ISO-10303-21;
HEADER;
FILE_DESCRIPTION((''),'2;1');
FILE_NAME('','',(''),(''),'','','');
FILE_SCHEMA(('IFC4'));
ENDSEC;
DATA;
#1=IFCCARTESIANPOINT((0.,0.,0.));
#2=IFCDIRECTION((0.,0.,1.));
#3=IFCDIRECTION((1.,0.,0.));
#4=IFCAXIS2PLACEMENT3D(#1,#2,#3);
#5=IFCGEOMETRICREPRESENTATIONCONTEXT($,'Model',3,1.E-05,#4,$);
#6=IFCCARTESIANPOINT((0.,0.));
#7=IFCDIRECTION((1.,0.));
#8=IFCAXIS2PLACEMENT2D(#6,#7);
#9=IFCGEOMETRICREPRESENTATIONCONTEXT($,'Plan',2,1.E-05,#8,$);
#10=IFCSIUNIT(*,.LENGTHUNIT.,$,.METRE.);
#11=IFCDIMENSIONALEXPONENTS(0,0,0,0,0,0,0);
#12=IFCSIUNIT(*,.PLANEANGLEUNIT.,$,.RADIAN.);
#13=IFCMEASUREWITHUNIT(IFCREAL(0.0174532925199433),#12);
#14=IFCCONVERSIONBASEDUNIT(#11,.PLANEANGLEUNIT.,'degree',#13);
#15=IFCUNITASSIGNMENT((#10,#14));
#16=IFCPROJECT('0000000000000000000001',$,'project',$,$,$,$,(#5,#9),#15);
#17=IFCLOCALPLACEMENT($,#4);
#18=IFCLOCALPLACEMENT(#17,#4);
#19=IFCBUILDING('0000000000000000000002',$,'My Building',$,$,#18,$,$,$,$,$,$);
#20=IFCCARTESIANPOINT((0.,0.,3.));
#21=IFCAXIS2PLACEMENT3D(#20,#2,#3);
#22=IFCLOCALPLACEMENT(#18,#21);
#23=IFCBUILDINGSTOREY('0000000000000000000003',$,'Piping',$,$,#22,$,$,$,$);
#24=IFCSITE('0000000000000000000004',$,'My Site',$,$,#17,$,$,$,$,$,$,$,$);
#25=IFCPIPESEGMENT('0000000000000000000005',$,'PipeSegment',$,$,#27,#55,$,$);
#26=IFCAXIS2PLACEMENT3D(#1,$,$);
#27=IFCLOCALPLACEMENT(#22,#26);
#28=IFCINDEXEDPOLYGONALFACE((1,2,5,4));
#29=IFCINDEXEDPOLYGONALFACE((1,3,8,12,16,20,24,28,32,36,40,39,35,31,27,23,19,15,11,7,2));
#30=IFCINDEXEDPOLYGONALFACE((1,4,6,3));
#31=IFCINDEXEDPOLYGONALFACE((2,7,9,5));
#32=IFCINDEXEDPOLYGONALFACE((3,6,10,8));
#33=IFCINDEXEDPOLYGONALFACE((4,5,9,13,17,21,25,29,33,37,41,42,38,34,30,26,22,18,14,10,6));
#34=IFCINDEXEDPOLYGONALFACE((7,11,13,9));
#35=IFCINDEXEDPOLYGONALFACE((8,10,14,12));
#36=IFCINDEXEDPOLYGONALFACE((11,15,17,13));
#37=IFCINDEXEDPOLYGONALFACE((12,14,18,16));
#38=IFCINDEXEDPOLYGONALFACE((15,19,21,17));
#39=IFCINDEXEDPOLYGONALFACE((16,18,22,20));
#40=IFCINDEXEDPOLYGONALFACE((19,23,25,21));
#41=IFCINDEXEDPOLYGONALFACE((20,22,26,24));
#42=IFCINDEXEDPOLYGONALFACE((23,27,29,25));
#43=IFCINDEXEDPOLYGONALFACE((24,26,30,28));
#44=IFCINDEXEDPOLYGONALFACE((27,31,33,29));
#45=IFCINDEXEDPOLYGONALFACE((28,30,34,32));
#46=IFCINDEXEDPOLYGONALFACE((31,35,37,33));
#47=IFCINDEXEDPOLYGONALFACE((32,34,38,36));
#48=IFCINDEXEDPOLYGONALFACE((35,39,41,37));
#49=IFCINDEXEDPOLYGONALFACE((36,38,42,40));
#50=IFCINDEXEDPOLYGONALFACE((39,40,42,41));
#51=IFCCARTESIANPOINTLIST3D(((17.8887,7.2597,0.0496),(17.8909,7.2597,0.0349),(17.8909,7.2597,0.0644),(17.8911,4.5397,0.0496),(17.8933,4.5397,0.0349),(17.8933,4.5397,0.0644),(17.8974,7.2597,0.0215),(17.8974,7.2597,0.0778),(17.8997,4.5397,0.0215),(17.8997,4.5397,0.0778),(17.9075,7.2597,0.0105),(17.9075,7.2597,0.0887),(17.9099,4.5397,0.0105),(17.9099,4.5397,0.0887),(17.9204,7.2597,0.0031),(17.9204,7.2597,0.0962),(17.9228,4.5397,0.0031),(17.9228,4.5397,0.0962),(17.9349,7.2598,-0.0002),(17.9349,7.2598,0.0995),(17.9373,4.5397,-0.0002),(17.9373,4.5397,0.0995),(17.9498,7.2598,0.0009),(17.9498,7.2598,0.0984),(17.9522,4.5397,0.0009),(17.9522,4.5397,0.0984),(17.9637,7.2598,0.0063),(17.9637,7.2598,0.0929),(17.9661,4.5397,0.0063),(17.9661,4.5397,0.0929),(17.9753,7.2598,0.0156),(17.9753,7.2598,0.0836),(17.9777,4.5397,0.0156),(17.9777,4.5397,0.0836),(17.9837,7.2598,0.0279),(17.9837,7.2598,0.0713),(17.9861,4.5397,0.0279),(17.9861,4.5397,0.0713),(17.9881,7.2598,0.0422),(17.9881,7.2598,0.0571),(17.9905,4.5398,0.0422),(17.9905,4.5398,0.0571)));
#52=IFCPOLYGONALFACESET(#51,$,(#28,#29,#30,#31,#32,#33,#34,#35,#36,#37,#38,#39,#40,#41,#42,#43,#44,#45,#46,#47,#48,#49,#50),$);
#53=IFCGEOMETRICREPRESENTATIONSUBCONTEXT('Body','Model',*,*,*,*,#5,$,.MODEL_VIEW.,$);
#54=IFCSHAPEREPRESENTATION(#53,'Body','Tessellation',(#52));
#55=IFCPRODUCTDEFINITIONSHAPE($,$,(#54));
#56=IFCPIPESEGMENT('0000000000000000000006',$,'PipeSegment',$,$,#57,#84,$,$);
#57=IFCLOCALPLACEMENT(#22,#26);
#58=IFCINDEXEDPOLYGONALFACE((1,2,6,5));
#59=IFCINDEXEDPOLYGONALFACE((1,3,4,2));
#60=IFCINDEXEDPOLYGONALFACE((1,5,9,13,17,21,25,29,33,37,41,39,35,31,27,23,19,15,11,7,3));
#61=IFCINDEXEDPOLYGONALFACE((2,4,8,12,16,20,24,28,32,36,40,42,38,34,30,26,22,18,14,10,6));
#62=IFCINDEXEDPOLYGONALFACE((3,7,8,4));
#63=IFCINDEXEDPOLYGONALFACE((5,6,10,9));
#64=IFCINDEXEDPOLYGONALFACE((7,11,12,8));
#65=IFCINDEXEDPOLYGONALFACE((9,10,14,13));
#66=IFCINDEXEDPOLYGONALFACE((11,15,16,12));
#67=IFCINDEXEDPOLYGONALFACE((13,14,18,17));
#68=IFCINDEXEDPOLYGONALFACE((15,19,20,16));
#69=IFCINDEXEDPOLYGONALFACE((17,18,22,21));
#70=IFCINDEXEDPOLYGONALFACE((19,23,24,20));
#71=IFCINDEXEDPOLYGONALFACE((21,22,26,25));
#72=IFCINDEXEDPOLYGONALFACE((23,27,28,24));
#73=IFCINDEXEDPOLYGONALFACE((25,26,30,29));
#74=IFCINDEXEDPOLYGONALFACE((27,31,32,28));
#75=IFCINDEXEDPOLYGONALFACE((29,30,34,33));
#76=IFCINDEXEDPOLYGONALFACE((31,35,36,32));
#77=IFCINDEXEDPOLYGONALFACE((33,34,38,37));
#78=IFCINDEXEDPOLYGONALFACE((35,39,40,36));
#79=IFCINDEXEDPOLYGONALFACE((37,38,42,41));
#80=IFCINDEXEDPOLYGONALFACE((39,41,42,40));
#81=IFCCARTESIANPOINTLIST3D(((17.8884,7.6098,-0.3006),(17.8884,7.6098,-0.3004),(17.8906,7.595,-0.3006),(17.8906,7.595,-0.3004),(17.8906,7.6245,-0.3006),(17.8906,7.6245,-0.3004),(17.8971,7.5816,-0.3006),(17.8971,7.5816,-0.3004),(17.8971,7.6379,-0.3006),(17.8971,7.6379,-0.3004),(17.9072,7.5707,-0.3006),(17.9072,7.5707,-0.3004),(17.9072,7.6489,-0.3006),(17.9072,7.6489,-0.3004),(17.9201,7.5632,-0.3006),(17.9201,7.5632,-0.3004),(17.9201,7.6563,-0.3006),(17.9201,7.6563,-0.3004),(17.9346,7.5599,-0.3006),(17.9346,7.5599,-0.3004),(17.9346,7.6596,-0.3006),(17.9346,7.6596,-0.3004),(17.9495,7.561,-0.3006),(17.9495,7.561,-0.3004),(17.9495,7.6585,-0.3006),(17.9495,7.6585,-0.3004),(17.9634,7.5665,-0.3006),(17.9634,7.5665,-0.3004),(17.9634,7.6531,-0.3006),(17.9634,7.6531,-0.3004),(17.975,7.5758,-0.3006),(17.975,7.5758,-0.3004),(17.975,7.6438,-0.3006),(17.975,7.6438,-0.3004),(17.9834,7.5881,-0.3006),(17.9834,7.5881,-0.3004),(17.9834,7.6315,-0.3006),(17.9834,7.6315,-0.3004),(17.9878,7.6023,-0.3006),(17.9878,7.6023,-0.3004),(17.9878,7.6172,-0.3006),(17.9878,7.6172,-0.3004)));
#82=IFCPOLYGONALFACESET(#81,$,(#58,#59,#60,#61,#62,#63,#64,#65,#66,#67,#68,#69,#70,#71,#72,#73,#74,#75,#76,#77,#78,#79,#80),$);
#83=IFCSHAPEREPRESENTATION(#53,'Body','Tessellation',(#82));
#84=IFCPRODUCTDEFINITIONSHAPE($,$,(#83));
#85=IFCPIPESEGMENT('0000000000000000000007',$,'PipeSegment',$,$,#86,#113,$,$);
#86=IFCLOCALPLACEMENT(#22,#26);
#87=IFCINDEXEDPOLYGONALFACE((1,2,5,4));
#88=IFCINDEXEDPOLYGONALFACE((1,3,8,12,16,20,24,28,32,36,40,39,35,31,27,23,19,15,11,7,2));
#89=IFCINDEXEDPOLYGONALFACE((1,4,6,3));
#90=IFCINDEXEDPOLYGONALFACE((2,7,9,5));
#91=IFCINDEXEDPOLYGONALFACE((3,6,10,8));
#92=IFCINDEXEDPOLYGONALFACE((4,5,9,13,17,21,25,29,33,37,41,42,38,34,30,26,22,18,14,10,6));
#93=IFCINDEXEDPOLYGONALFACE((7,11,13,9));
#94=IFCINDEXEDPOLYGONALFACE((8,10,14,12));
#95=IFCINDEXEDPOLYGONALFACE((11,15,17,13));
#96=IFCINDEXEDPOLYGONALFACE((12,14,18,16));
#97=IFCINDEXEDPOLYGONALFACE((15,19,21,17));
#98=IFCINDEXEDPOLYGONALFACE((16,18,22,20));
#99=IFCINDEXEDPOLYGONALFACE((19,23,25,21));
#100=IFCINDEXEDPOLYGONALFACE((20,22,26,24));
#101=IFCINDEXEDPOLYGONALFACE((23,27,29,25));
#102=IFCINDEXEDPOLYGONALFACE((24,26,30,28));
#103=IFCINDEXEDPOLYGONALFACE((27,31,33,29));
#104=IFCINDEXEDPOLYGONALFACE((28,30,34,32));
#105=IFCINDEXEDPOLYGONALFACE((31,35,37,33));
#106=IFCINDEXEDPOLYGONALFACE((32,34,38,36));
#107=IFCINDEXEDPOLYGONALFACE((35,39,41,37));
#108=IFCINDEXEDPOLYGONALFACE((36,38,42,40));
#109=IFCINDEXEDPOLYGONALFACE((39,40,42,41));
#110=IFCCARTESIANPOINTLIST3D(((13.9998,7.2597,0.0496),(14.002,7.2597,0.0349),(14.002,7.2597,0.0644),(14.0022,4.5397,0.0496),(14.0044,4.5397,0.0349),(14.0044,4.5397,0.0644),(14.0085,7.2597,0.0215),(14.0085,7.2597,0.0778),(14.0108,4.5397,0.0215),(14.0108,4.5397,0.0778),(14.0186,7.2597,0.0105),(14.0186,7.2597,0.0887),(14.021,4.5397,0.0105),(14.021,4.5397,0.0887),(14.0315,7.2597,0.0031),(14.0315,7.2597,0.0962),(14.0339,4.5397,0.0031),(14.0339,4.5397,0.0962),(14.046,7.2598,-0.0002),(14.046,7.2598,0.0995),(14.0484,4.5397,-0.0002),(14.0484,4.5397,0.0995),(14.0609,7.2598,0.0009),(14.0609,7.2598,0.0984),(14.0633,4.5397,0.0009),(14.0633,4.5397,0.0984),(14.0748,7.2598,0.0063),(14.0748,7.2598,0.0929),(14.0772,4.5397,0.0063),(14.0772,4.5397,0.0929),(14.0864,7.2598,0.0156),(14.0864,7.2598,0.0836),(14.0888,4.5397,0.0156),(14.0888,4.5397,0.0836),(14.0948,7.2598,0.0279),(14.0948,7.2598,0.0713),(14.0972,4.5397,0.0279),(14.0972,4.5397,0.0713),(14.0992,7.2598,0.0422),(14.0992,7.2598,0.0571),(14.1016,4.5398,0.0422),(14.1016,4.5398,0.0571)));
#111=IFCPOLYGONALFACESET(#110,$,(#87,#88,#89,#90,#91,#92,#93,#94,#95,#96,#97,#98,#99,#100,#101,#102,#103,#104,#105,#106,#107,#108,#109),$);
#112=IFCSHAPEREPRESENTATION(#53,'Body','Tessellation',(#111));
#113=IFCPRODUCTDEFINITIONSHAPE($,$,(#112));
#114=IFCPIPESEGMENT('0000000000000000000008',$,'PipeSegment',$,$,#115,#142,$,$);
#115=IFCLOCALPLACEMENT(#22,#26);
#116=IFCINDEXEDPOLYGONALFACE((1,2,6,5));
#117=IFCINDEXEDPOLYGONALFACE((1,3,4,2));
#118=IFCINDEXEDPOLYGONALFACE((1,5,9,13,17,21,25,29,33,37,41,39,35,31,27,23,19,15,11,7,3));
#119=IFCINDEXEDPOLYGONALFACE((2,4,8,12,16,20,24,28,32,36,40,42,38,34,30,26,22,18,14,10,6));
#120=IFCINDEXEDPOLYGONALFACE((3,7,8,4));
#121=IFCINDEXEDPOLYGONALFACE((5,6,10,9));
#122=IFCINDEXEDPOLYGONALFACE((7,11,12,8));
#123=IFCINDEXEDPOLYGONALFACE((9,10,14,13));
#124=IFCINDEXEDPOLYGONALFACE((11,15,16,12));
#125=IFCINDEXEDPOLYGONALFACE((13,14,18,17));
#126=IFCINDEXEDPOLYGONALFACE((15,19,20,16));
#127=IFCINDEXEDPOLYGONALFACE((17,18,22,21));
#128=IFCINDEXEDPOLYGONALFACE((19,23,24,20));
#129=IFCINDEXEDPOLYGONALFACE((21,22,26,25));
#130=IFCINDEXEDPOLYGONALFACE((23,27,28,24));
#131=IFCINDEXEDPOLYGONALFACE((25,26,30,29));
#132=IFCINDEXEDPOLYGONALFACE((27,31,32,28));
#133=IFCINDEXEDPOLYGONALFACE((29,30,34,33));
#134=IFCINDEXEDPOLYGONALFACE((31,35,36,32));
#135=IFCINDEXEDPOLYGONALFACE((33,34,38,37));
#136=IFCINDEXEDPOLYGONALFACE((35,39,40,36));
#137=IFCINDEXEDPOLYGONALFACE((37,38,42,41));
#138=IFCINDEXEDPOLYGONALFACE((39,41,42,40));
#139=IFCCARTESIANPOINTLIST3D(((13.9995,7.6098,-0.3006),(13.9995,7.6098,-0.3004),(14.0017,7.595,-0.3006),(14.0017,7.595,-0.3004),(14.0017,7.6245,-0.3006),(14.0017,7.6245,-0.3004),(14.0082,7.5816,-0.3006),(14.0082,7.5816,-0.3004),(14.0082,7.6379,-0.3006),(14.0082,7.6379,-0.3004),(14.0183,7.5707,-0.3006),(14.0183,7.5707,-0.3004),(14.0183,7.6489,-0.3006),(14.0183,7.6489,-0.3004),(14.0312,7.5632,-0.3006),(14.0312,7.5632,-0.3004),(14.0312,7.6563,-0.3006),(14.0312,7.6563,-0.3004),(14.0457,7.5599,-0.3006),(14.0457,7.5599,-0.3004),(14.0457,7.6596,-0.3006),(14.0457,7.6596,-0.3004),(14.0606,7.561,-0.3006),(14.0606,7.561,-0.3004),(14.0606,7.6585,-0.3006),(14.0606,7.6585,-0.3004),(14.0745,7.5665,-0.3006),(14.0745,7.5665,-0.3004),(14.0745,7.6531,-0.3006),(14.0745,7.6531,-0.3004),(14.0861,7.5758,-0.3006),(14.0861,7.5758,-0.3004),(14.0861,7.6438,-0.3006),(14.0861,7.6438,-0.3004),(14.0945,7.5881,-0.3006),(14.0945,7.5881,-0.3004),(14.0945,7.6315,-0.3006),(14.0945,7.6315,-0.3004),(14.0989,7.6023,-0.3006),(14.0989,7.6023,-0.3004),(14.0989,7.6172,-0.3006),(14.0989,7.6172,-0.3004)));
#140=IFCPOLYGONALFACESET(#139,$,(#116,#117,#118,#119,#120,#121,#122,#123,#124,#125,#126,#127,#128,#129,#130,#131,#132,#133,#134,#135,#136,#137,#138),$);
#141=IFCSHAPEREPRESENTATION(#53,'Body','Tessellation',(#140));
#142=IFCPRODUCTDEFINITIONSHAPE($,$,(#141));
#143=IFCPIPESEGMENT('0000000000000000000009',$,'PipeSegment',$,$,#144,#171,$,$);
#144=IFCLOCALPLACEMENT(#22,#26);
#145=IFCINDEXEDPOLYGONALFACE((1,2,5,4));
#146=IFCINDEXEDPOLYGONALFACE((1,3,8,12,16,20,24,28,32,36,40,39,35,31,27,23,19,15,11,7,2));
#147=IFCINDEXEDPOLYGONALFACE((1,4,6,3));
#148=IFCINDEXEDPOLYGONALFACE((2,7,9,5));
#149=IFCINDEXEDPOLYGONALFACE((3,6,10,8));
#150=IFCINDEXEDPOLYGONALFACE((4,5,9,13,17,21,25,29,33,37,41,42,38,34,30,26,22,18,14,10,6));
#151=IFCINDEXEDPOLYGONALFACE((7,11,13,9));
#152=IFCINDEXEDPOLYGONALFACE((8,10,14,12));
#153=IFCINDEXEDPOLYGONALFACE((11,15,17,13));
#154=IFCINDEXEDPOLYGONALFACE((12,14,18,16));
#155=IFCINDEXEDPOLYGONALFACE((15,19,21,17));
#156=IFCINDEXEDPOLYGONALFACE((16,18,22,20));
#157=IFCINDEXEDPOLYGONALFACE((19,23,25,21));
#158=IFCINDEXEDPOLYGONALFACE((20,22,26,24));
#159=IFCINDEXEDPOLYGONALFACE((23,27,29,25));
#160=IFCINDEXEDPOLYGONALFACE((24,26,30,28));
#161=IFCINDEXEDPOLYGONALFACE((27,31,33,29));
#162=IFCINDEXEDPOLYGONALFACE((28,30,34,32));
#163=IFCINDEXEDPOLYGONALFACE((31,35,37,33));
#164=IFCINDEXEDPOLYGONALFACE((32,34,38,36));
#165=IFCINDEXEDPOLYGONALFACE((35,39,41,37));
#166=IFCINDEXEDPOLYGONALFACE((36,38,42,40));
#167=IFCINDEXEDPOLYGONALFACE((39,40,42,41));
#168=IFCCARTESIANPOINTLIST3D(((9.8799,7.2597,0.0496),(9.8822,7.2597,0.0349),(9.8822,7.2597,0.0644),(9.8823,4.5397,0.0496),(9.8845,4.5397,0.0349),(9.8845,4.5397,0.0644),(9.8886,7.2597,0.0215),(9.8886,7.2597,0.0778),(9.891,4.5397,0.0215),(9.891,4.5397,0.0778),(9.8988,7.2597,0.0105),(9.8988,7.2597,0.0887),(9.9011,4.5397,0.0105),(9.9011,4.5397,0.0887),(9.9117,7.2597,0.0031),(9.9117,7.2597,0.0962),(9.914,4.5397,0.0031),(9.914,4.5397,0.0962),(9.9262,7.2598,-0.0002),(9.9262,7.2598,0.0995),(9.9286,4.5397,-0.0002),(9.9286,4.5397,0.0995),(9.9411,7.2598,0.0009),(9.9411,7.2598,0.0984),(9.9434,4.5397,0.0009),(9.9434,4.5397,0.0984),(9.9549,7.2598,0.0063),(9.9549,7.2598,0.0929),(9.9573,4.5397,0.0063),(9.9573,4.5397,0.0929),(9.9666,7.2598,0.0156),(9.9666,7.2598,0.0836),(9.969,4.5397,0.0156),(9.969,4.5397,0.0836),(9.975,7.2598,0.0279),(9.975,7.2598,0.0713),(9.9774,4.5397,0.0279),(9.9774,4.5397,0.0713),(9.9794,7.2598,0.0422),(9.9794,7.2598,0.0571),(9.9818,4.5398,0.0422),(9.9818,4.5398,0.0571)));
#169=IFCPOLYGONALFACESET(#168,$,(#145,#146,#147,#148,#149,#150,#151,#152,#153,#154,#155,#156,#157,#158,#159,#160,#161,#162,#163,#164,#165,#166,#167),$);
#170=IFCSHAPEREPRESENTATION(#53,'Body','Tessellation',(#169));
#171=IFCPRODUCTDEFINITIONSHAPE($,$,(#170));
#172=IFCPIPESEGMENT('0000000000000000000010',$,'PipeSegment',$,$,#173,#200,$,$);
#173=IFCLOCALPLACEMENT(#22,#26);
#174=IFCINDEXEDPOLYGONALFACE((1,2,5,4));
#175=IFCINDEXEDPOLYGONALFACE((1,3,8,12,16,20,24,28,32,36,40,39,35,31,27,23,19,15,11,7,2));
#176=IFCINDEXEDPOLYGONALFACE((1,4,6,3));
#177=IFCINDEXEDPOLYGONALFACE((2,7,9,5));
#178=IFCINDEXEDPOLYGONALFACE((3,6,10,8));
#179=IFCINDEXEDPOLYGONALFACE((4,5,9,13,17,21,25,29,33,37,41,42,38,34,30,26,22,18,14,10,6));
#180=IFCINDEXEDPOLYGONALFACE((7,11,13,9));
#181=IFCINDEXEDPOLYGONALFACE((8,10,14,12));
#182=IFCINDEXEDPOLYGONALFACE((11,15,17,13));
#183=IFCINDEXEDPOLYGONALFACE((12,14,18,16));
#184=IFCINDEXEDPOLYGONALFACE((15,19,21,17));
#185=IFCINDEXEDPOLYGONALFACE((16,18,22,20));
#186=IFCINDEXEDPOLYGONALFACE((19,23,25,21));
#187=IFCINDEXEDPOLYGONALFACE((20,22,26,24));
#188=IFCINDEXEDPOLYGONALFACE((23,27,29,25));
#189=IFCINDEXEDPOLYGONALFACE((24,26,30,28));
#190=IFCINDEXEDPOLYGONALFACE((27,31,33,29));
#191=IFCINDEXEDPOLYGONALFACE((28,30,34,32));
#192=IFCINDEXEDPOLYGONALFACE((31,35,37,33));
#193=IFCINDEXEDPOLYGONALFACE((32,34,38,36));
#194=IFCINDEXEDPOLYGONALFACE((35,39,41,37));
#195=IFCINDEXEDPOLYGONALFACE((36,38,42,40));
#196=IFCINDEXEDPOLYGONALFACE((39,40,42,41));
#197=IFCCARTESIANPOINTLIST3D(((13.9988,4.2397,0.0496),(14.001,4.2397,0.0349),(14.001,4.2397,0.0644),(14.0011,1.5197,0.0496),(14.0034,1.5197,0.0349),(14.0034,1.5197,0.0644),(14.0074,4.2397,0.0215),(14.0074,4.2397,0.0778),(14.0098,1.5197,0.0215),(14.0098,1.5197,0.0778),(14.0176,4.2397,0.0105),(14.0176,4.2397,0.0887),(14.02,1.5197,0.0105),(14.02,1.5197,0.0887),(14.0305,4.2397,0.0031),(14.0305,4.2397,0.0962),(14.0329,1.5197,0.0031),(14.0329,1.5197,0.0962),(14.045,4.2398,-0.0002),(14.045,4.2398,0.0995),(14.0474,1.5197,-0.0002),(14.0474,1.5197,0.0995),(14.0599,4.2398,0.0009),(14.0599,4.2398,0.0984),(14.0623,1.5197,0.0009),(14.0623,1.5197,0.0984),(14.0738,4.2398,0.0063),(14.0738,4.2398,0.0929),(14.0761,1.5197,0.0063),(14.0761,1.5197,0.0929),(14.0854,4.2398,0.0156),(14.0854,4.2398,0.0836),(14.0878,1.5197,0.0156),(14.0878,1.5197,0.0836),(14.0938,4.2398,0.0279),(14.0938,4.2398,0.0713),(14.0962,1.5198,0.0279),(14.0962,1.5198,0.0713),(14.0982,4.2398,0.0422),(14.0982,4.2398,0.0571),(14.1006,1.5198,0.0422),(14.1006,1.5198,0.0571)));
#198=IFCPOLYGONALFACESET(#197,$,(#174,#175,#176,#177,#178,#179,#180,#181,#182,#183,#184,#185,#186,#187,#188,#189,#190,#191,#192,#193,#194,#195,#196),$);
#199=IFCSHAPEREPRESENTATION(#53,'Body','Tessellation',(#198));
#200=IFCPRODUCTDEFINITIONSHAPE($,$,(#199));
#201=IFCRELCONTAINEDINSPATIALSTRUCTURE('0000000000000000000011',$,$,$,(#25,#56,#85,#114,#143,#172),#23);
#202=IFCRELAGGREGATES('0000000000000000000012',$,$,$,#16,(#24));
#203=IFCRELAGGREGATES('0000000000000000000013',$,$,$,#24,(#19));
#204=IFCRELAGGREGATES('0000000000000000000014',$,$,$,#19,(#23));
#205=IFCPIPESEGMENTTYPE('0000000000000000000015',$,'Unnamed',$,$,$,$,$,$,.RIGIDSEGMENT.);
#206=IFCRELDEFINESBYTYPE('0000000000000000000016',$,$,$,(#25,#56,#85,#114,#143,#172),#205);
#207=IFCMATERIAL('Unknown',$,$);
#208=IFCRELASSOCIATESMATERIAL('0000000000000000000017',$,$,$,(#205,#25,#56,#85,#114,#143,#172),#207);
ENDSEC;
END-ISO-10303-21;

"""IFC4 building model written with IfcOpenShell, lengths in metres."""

from ifc_helpers import new_model, entity, si_unit, converted_unit, frame, origin_with_axes, origin_2d_with_axis, place, context, subcontext, project, spatial, circle, extrude, material, material_profile, profile_set, profile_usage, type_object, element, save


model = new_model("IFC4")

# Units and contexts
model_context = context("Model", 3, precision=1e-05, world=origin_with_axes())
plan_context = context("Plan", 2, precision=1e-05, world=origin_2d_with_axis())
body_context = subcontext(model_context, "Body", "Model", "MODEL_VIEW")
ifc_project = project(units=[si_unit("LENGTHUNIT", "METRE"), converted_unit("PLANEANGLEUNIT", "degree", entity("IfcReal", 0.0174532925199433), si_unit("PLANEANGLEUNIT", "RADIAN"), dimensions=[0, 0, 0, 0, 0, 0, 0])], contexts=[model_context, plan_context])

# Site, building, storey
site_placement = place(None, origin_with_axes())
site = spatial("IfcSite", under=ifc_project, at=site_placement, Name="My Site")
building_placement = place(site_placement, origin_with_axes())
building = spatial("IfcBuilding", under=site, at=building_placement, Name="My Building")
storey_placement = place(building_placement, frame((0.0, 0.0, 3.0), z_axis=(0.0, 0.0, 1.0), x_axis=(1.0, 0.0, 0.0)))
storey = spatial("IfcBuildingStorey", under=building, at=storey_placement, Name="Piping")

# Pipe segments
ifc_material = material(Name="Unknown")
ifc_material_profile_1 = material_profile(ifc_material, circle(Radius=0.05))
ifc_profile_set_1 = profile_set([ifc_material_profile_1])
ifc_profile_usage_1 = profile_usage(ifc_profile_set_1, cardinal=5)
pipe_segment_type = type_object("IfcPipeSegmentType", Name="Unnamed", PredefinedType="RIGIDSEGMENT", material=ifc_profile_set_1)
pipe_segment_1_placement = place(storey_placement, frame((17.9411, 4.5397, 0.0496), z_axis=(-0.000872, 1.0, 0.000001), x_axis=(-1.0, -0.000872, 0.0)))
element("IfcPipeSegment", 1, at=pipe_segment_1_placement, inside=storey, type_object=pipe_segment_type, material=ifc_profile_usage_1, Name="PipeSegment", context=body_context, shape_type="SweptSolid", body=[
    extrude(circle(Radius=0.05), origin_with_axes(), (0.0, 0.0, 1.0), 2.7201),
])
ifc_profile_usage_2 = profile_usage(ifc_profile_set_1, cardinal=16)
pipe_segment_2_placement = place(storey_placement, frame((17.9384, 7.6098, -0.3004), z_axis=(0.0, 0.0, -1.0), x_axis=(-1.0, 0.0, 0.0)))
element("IfcPipeSegment", 2, at=pipe_segment_2_placement, inside=storey, type_object=pipe_segment_type, material=ifc_profile_usage_2, Name="PipeSegment", context=body_context, shape_type="SweptSolid", body=[
    extrude(circle(Radius=0.05), origin_with_axes(), (0.0, 0.0, 1.0), 0.0002),
])
ifc_profile_usage_3 = profile_usage(ifc_profile_set_1, cardinal=5)
pipe_segment_3_placement = place(storey_placement, frame((14.0522, 4.5397, 0.0496), z_axis=(-0.000872, 1.0, 0.000001), x_axis=(-1.0, -0.000872, 0.0)))
element("IfcPipeSegment", 3, at=pipe_segment_3_placement, inside=storey, type_object=pipe_segment_type, material=ifc_profile_usage_3, Name="PipeSegment", context=body_context, shape_type="SweptSolid", body=[
    extrude(circle(Radius=0.05), origin_with_axes(), (0.0, 0.0, 1.0), 2.7201),
])
ifc_profile_usage_4 = profile_usage(ifc_profile_set_1, cardinal=16)
pipe_segment_4_placement = place(storey_placement, frame((14.0495, 7.6098, -0.3004), z_axis=(0.0, 0.0, -1.0), x_axis=(-1.0, 0.0, 0.0)))
element("IfcPipeSegment", 4, at=pipe_segment_4_placement, inside=storey, type_object=pipe_segment_type, material=ifc_profile_usage_4, Name="PipeSegment", context=body_context, shape_type="SweptSolid", body=[
    extrude(circle(Radius=0.05), origin_with_axes(), (0.0, 0.0, 1.0), 0.0002),
])
ifc_profile_usage_5 = profile_usage(ifc_profile_set_1, cardinal=5)
pipe_segment_5_placement = place(storey_placement, frame((9.9323, 4.5397, 0.0496), z_axis=(-0.000872, 1.0, 0.000001), x_axis=(-1.0, -0.000872, 0.0)))
element("IfcPipeSegment", 5, at=pipe_segment_5_placement, inside=storey, type_object=pipe_segment_type, material=ifc_profile_usage_5, Name="PipeSegment", context=body_context, shape_type="SweptSolid", body=[
    extrude(circle(Radius=0.05), origin_with_axes(), (0.0, 0.0, 1.0), 2.7201),
])
ifc_profile_usage_6 = profile_usage(ifc_profile_set_1, cardinal=5)
pipe_segment_6_placement = place(storey_placement, frame((14.0511, 1.5197, 0.0496), z_axis=(-0.000873, 1.0, 0.000001), x_axis=(-1.0, -0.000873, 0.0)))
element("IfcPipeSegment", 6, at=pipe_segment_6_placement, inside=storey, type_object=pipe_segment_type, material=ifc_profile_usage_6, Name="PipeSegment", context=body_context, shape_type="SweptSolid", body=[
    extrude(circle(Radius=0.05), origin_with_axes(), (0.0, 0.0, 1.0), 2.7201),
])

save(model, "model.ifc")
